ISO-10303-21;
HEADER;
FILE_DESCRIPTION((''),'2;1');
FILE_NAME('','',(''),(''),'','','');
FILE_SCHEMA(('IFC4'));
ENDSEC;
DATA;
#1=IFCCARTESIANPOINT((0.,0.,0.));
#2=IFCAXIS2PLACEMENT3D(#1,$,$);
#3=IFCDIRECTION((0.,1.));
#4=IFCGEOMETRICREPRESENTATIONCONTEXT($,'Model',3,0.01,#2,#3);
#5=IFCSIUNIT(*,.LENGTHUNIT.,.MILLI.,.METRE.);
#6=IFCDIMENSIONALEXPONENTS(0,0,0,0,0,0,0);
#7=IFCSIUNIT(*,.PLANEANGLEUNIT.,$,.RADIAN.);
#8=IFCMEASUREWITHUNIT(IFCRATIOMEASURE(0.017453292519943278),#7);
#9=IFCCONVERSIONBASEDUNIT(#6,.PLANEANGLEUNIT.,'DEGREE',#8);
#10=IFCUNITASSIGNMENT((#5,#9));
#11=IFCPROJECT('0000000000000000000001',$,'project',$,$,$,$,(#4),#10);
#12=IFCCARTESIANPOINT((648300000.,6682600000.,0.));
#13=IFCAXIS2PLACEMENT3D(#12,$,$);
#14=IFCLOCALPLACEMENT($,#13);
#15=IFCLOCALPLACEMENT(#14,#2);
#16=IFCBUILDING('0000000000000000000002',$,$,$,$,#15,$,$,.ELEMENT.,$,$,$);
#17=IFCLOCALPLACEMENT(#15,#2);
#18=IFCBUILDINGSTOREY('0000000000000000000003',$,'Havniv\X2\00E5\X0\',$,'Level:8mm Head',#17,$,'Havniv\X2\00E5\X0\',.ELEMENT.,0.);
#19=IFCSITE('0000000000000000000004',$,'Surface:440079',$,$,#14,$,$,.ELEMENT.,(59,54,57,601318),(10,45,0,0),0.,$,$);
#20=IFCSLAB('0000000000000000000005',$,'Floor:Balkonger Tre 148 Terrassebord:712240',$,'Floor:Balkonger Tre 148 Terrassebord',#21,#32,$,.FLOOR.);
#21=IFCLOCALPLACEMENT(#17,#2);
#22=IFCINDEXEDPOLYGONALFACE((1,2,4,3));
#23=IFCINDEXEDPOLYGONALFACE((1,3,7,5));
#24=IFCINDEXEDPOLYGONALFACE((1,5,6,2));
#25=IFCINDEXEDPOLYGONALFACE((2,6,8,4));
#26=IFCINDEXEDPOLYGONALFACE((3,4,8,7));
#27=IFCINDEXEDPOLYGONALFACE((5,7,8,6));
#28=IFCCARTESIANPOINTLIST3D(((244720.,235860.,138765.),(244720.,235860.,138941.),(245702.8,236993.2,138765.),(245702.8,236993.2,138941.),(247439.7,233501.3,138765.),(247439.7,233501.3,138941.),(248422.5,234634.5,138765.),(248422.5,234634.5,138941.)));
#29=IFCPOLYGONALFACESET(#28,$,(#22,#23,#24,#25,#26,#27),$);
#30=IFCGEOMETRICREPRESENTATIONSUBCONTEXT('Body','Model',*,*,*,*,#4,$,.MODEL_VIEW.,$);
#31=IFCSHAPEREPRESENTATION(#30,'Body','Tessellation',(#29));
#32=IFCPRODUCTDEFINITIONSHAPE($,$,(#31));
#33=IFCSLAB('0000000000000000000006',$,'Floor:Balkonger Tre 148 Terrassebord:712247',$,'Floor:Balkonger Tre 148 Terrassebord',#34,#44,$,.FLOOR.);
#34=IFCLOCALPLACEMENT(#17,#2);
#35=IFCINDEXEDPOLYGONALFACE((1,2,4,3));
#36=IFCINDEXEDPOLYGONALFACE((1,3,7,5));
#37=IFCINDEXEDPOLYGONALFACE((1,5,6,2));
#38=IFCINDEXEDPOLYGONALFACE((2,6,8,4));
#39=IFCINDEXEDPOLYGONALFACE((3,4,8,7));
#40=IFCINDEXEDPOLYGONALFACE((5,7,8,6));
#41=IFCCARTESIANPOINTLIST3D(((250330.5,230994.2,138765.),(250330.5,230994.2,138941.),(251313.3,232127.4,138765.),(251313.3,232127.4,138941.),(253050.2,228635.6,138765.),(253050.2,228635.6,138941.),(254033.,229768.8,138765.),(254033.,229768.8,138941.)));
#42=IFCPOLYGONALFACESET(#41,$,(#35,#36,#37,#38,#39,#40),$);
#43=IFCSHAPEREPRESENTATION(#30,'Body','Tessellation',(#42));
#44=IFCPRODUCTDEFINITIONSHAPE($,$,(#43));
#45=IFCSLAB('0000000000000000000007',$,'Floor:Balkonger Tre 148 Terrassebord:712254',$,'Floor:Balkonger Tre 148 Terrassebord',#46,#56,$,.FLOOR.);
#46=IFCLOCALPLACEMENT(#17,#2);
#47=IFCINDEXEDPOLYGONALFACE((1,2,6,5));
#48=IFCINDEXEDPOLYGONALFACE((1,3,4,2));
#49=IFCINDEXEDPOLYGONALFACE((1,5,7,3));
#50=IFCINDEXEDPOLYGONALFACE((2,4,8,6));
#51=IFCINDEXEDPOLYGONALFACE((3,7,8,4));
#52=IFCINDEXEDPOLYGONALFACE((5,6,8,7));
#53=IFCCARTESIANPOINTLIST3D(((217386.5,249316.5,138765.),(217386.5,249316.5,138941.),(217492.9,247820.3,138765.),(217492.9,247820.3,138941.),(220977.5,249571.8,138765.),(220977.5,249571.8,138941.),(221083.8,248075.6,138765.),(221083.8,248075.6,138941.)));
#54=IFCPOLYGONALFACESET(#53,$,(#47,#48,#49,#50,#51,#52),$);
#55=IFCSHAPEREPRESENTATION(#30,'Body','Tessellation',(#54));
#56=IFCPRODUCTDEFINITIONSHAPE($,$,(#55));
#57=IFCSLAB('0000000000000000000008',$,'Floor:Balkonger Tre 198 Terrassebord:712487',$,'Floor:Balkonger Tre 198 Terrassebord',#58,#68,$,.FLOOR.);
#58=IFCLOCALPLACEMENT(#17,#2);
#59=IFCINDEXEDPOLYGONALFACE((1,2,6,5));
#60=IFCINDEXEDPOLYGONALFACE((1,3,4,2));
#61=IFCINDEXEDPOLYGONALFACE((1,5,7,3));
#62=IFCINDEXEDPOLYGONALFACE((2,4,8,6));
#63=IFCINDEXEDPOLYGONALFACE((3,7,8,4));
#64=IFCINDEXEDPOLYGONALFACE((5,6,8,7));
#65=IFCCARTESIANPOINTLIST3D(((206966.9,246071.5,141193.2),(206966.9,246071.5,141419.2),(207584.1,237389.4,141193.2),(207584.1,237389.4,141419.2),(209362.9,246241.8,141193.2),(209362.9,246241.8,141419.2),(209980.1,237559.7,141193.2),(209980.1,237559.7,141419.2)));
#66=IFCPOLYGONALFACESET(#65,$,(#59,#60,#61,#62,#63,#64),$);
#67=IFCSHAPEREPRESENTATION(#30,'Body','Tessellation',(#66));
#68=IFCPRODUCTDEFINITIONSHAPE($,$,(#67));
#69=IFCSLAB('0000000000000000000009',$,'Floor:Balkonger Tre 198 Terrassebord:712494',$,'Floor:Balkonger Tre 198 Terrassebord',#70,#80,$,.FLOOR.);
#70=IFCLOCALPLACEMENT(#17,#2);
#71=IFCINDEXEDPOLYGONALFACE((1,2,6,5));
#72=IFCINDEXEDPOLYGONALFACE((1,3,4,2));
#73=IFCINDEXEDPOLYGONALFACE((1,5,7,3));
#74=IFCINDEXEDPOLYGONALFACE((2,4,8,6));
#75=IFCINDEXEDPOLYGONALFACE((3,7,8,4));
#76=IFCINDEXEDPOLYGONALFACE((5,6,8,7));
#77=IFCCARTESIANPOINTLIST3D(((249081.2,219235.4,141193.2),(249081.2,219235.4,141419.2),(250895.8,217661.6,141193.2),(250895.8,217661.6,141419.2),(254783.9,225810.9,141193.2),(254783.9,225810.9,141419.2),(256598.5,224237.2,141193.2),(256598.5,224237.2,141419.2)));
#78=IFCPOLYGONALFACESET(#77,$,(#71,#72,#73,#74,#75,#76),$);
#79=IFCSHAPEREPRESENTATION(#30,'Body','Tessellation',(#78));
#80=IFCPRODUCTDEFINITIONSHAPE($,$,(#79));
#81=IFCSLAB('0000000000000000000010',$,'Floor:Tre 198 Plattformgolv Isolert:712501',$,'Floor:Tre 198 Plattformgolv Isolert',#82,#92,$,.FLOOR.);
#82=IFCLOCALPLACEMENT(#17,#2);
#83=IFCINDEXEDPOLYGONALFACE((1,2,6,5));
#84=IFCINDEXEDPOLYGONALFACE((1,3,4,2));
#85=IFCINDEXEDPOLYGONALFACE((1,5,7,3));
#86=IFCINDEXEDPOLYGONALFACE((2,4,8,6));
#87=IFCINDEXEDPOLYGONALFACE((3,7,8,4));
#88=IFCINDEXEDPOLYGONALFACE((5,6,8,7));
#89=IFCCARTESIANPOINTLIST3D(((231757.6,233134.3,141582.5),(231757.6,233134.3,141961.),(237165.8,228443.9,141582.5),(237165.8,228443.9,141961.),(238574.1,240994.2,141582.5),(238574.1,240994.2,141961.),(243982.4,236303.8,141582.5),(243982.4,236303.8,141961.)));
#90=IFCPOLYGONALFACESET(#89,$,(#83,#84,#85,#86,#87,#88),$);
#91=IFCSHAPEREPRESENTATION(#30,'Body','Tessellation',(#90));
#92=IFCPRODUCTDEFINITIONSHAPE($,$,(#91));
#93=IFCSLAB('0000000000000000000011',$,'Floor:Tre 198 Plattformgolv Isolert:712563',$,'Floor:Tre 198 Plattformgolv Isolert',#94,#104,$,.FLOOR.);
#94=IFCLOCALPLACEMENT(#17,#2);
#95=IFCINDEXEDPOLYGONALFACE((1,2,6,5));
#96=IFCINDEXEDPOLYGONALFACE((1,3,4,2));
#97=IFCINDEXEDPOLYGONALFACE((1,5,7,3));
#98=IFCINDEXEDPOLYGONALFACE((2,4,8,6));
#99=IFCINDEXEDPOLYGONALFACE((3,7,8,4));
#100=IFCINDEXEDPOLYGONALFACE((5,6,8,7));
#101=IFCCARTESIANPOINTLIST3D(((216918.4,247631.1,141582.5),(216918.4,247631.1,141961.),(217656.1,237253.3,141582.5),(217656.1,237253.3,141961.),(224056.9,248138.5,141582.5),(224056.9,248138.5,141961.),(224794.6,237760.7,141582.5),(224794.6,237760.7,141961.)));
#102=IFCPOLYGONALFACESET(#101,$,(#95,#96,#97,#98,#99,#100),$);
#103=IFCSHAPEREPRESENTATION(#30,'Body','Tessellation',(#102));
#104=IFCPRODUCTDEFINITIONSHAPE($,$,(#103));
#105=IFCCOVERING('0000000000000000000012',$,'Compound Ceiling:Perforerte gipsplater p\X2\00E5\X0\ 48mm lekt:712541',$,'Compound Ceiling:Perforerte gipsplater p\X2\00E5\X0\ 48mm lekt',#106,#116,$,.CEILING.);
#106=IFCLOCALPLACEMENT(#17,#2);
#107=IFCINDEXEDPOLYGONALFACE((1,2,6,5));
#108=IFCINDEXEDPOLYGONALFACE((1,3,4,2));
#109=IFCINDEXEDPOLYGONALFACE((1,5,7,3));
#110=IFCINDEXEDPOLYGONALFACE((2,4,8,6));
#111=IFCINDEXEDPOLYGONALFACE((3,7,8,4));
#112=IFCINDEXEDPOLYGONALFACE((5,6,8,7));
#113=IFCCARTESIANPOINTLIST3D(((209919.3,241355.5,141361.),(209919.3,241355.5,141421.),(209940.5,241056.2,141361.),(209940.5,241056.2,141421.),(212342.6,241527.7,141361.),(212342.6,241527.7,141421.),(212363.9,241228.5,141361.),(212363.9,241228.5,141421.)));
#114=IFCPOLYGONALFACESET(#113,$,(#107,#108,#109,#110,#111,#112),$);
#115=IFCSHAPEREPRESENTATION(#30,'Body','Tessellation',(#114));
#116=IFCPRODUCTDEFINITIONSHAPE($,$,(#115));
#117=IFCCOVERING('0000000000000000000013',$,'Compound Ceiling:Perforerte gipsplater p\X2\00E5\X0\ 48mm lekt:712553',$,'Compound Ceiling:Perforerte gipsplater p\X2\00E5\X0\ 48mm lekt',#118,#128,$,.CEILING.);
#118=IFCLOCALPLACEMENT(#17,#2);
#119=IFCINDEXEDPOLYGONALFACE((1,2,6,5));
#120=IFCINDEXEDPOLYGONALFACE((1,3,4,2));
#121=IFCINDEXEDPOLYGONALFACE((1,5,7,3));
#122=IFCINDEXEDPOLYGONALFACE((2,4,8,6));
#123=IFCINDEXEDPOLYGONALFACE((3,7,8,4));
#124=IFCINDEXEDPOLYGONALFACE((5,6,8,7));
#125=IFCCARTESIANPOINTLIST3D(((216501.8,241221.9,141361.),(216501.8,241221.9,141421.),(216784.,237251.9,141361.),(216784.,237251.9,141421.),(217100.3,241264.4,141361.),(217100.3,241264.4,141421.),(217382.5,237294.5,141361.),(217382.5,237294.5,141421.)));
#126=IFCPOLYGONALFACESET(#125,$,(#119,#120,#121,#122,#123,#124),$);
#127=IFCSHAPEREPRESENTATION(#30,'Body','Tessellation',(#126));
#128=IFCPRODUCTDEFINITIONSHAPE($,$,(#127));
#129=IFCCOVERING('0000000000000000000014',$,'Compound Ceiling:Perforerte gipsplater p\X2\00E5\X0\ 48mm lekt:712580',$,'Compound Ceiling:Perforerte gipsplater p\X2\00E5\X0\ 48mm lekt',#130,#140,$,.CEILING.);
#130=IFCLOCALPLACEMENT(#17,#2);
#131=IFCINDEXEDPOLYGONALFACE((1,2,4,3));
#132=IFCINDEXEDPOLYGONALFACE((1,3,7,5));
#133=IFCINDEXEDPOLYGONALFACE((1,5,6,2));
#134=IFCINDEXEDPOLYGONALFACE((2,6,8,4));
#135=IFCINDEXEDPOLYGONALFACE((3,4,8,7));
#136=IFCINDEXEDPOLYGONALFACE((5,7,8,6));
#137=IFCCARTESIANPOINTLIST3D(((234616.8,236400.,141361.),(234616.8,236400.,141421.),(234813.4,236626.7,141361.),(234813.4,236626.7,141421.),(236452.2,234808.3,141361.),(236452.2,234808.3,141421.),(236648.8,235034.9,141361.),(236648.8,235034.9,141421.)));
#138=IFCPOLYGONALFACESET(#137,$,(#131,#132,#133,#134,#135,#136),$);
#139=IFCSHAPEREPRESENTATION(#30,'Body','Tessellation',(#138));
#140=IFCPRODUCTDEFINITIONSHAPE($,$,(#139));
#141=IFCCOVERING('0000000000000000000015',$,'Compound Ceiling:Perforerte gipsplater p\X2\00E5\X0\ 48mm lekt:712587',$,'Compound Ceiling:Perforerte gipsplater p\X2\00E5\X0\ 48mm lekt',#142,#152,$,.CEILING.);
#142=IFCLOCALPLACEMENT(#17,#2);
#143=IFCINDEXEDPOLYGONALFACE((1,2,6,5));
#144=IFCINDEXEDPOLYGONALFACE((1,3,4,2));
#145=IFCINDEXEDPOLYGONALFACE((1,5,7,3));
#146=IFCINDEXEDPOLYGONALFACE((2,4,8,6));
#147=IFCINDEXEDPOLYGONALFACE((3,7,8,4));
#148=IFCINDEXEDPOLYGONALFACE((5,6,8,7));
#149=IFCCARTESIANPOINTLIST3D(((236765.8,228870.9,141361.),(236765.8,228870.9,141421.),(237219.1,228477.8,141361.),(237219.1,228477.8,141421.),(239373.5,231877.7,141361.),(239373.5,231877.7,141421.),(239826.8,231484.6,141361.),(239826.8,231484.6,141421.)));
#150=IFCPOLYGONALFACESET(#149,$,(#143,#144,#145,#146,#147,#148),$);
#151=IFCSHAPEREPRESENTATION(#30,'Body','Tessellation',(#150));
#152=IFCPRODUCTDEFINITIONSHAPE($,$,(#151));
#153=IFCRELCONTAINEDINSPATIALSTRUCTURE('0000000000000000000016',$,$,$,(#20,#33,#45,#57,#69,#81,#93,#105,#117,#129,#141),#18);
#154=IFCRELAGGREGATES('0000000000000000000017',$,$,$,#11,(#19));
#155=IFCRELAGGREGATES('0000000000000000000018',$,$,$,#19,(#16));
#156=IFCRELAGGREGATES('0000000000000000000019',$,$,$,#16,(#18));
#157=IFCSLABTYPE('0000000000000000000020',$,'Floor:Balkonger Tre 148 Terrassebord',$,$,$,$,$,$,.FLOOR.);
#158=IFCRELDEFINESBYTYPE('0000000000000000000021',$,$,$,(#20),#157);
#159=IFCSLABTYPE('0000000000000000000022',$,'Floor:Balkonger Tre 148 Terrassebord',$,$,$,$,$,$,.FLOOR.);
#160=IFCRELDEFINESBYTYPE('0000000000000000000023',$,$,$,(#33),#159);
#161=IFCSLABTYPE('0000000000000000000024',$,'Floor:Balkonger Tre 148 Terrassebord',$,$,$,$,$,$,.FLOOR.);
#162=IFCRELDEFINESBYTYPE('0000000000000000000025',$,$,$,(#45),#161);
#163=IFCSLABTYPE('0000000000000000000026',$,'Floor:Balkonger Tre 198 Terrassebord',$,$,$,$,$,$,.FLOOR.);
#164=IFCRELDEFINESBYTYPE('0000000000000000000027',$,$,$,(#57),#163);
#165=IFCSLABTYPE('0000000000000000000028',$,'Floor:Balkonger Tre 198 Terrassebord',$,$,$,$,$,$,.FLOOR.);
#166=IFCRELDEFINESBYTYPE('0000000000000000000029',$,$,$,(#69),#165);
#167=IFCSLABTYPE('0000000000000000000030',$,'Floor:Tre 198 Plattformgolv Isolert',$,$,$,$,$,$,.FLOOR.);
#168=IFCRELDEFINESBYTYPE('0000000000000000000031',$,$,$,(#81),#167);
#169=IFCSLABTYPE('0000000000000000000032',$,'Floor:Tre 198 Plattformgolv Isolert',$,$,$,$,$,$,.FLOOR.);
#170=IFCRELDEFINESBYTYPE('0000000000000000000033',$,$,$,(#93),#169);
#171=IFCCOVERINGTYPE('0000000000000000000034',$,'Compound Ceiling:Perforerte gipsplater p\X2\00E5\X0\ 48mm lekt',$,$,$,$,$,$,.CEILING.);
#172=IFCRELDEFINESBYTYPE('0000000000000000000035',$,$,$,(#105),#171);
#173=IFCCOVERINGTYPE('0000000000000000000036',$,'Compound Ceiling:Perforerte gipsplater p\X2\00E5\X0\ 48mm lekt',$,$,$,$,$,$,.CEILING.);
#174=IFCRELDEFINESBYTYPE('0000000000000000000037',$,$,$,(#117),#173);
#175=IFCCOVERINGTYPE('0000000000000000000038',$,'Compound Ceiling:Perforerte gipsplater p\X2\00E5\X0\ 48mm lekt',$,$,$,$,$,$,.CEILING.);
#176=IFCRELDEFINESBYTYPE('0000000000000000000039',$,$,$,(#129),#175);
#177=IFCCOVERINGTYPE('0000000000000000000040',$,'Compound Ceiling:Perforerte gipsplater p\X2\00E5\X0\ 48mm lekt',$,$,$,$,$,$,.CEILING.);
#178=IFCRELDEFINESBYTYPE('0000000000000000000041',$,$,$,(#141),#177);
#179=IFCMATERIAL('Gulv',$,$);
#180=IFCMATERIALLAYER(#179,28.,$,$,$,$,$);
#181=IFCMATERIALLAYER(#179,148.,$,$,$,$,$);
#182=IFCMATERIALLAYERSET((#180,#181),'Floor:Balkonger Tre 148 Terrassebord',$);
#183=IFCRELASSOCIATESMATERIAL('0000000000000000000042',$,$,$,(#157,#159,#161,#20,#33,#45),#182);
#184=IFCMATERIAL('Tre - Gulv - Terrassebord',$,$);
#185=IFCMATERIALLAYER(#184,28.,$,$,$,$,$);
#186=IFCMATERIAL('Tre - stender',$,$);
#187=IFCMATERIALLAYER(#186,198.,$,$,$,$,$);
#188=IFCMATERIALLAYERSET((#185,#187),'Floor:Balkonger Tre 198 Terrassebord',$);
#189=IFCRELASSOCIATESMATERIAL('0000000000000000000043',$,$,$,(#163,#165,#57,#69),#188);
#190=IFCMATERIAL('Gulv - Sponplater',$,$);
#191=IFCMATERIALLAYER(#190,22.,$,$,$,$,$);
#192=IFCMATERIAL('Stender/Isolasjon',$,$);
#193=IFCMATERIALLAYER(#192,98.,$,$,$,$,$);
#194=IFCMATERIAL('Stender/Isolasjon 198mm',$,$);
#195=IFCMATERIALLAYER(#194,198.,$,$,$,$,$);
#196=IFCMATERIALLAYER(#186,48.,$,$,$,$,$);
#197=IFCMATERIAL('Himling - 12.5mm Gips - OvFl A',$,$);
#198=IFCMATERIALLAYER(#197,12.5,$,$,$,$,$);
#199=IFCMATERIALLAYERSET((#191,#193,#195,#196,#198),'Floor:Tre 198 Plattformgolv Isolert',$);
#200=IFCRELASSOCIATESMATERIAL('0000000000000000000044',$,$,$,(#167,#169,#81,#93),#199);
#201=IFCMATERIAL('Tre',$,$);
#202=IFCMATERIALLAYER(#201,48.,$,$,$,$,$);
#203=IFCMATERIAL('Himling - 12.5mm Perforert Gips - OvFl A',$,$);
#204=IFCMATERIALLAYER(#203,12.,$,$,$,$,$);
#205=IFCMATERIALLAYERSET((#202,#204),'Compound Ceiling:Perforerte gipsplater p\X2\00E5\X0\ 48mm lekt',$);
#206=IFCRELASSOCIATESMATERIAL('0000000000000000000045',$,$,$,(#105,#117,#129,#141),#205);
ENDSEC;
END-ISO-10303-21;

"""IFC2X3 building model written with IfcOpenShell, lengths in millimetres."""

from ifc_helpers import new_model, entity, si_unit, converted_unit, direction, frame, frame_2d, origin, place, context, subcontext, project, spatial, rectangle, extrude, material, layer, layer_set, layer_usage, type_object, element, save


model = new_model("IFC2X3")

# Units and contexts
model_context = context("Model", 3, precision=0.01, world=origin(), true_north=direction((0.0, 1.0)))
body_context = subcontext(model_context, "Body", "Model", "MODEL_VIEW")
ifc_project = project(units=[si_unit("LENGTHUNIT", "METRE", prefix="MILLI"), converted_unit("PLANEANGLEUNIT", "DEGREE", entity("IfcRatioMeasure", 0.017453292519943278), si_unit("PLANEANGLEUNIT", "RADIAN"), dimensions=[0, 0, 0, 0, 0, 0, 0])], contexts=[model_context])

# Site, building, storey
site_placement = place(None, frame((648300000.0, 6682600000.0, 0.0)))
site = spatial("IfcSite", under=ifc_project, at=site_placement, Name="Surface:440079", CompositionType="ELEMENT", RefLatitude=(59, 54, 57, 601318), RefLongitude=(10, 45, 0, 0), RefElevation=0.0)
building_placement = place(site_placement, origin())
building = spatial("IfcBuilding", under=site, at=building_placement, CompositionType="ELEMENT")
storey_placement = place(building_placement, origin())
storey = spatial("IfcBuildingStorey", under=building, at=storey_placement, Name="Havnivå", ObjectType="Level:8mm Head", LongName="Havnivå", CompositionType="ELEMENT", Elevation=0.0)

# Slabs
ifc_material_1 = material(Name="Gulv")
ifc_layer_1 = layer(ifc_material_1, 28.0)
ifc_layer_2 = layer(ifc_material_1, 148.0)
ifc_layer_set_1 = layer_set([ifc_layer_1, ifc_layer_2], Name="Floor:Balkonger Tre 148 Terrassebord")
ifc_material_2 = material(Name="Gulv - Sponplater")
ifc_layer_3 = layer(ifc_material_2, 22.0)
ifc_material_3 = material(Name="Stender/Isolasjon")
ifc_layer_4 = layer(ifc_material_3, 98.0)
ifc_material_4 = material(Name="Stender/Isolasjon 198mm")
ifc_layer_5 = layer(ifc_material_4, 198.0)
ifc_material_5 = material(Name="Tre - stender")
ifc_layer_6 = layer(ifc_material_5, 48.0)
ifc_material_6 = material(Name="Himling - 12.5mm Gips - OvFl A")
ifc_layer_7 = layer(ifc_material_6, 12.5)
ifc_layer_set_2 = layer_set([ifc_layer_3, ifc_layer_4, ifc_layer_5, ifc_layer_6, ifc_layer_7], Name="Floor:Tre 198 Plattformgolv Isolert")
ifc_layer_usage_1 = layer_usage(ifc_layer_set_1, "AXIS3", "POSITIVE", 0.0)
slab_type_1 = type_object("IfcSlabType", Name="Floor:Balkonger Tre 148 Terrassebord", PredefinedType="FLOOR", material=ifc_layer_set_1)
slab_1_placement = place(storey_placement, origin())
element("IfcSlab", 1, at=slab_1_placement, inside=storey, type_object=slab_type_1, material=ifc_layer_usage_1, Name="Floor:Balkonger Tre 148 Terrassebord:712240", ObjectType="Floor:Balkonger Tre 148 Terrassebord", PredefinedType="FLOOR", context=body_context, shape_type="SweptSolid", body=[
    extrude(rectangle(XDim=1500.0, YDim=3600.0, at=frame_2d((0.0, 0.0), x_axis=(1.0, 0.0))), frame((246571.3, 235247.2, 138941.0), z_axis=(0.0, 0.0, -1.0), x_axis=(-0.655187, -0.755467, 0.0)), (0.0, 0.0, 1.0), 176.0),
])
ifc_layer_usage_2 = layer_usage(ifc_layer_set_1, "AXIS3", "POSITIVE", 0.0)
slab_type_2 = type_object("IfcSlabType", Name="Floor:Balkonger Tre 148 Terrassebord", PredefinedType="FLOOR", material=ifc_layer_set_1)
slab_2_placement = place(storey_placement, origin())
element("IfcSlab", 2, at=slab_2_placement, inside=storey, type_object=slab_type_2, material=ifc_layer_usage_2, Name="Floor:Balkonger Tre 148 Terrassebord:712247", ObjectType="Floor:Balkonger Tre 148 Terrassebord", PredefinedType="FLOOR", context=body_context, shape_type="SweptSolid", body=[
    extrude(rectangle(XDim=1500.0, YDim=3600.0, at=frame_2d((0.0, 0.0), x_axis=(1.0, 0.0))), frame((252181.7, 230381.5, 138941.0), z_axis=(0.0, 0.0, -1.0), x_axis=(-0.655187, -0.755467, 0.0)), (0.0, 0.0, 1.0), 176.0),
])
ifc_layer_usage_3 = layer_usage(ifc_layer_set_1, "AXIS3", "POSITIVE", 0.0)
slab_type_3 = type_object("IfcSlabType", Name="Floor:Balkonger Tre 148 Terrassebord", PredefinedType="FLOOR", material=ifc_layer_set_1)
slab_3_placement = place(storey_placement, origin())
element("IfcSlab", 3, at=slab_3_placement, inside=storey, type_object=slab_type_3, material=ifc_layer_usage_3, Name="Floor:Balkonger Tre 148 Terrassebord:712254", ObjectType="Floor:Balkonger Tre 148 Terrassebord", PredefinedType="FLOOR", context=body_context, shape_type="SweptSolid", body=[
    extrude(rectangle(XDim=1500.0, YDim=3600.0, at=frame_2d((0.0, 0.0), x_axis=(1.0, 0.0))), frame((219235.2, 248696.0, 138941.0), z_axis=(0.0, 0.0, -1.0), x_axis=(0.070908, -0.997483, 0.0)), (0.0, 0.0, 1.0), 176.0),
])
ifc_material_7 = material(Name="Tre - Gulv - Terrassebord")
ifc_layer_8 = layer(ifc_material_7, 28.0)
ifc_layer_9 = layer(ifc_material_5, 198.0)
ifc_layer_set_3 = layer_set([ifc_layer_8, ifc_layer_9], Name="Floor:Balkonger Tre 198 Terrassebord")
ifc_layer_usage_4 = layer_usage(ifc_layer_set_3, "AXIS3", "POSITIVE", 0.0)
slab_type_4 = type_object("IfcSlabType", Name="Floor:Balkonger Tre 198 Terrassebord", PredefinedType="FLOOR", material=ifc_layer_set_3)
slab_4_placement = place(storey_placement, origin())
element("IfcSlab", 4, at=slab_4_placement, inside=storey, type_object=slab_type_4, material=ifc_layer_usage_4, Name="Floor:Balkonger Tre 198 Terrassebord:712487", ObjectType="Floor:Balkonger Tre 198 Terrassebord", PredefinedType="FLOOR", context=body_context, shape_type="SweptSolid", body=[
    extrude(rectangle(XDim=2402.0, YDim=8704.0, at=frame_2d((0.0, 0.0), x_axis=(1.0, 0.0))), frame((208473.5, 241815.6, 141419.2), z_axis=(0.0, 0.0, -1.0), x_axis=(0.997483, 0.070908, 0.0)), (0.0, 0.0, 1.0), 226.0),
])
ifc_layer_usage_5 = layer_usage(ifc_layer_set_3, "AXIS3", "POSITIVE", 0.0)
slab_type_5 = type_object("IfcSlabType", Name="Floor:Balkonger Tre 198 Terrassebord", PredefinedType="FLOOR", material=ifc_layer_set_3)
slab_5_placement = place(storey_placement, origin())
element("IfcSlab", 5, at=slab_5_placement, inside=storey, type_object=slab_type_5, material=ifc_layer_usage_5, Name="Floor:Balkonger Tre 198 Terrassebord:712494", ObjectType="Floor:Balkonger Tre 198 Terrassebord", PredefinedType="FLOOR", context=body_context, shape_type="SweptSolid", body=[
    extrude(rectangle(XDim=8704.0, YDim=2402.0, at=frame_2d((0.0, 0.0), x_axis=(1.0, 0.0))), frame((252839.8, 221736.3, 141419.2), z_axis=(0.0, 0.0, -1.0), x_axis=(-0.655187, -0.755467, 0.0)), (0.0, 0.0, 1.0), 226.0),
])
ifc_layer_usage_6 = layer_usage(ifc_layer_set_2, "AXIS3", "POSITIVE", 0.0)
slab_type_6 = type_object("IfcSlabType", Name="Floor:Tre 198 Plattformgolv Isolert", PredefinedType="FLOOR", material=ifc_layer_set_2)
slab_6_placement = place(storey_placement, origin())
element("IfcSlab", 6, at=slab_6_placement, inside=storey, type_object=slab_type_6, material=ifc_layer_usage_6, Name="Floor:Tre 198 Plattformgolv Isolert:712501", ObjectType="Floor:Tre 198 Plattformgolv Isolert", PredefinedType="FLOOR", context=body_context, shape_type="SweptSolid", body=[
    extrude(rectangle(XDim=7158.8, YDim=10404.0, at=frame_2d((0.0, 0.0), x_axis=(1.0, 0.0))), frame((237870.0, 234719.1, 141961.0), z_axis=(0.0, 0.0, -1.0), x_axis=(0.755467, -0.655187, 0.0)), (0.0, 0.0, 1.0), 378.5),
])
ifc_layer_usage_7 = layer_usage(ifc_layer_set_2, "AXIS3", "POSITIVE", 0.0)
slab_type_7 = type_object("IfcSlabType", Name="Floor:Tre 198 Plattformgolv Isolert", PredefinedType="FLOOR", material=ifc_layer_set_2)
slab_7_placement = place(storey_placement, origin())
element("IfcSlab", 7, at=slab_7_placement, inside=storey, type_object=slab_type_7, material=ifc_layer_usage_7, Name="Floor:Tre 198 Plattformgolv Isolert:712563", ObjectType="Floor:Tre 198 Plattformgolv Isolert", PredefinedType="FLOOR", context=body_context, shape_type="SweptSolid", body=[
    extrude(rectangle(XDim=10404.0, YDim=7156.5, at=frame_2d((0.0, 0.0), x_axis=(1.0, 0.0))), frame((220856.5, 242695.9, 141961.0), z_axis=(0.0, 0.0, -1.0), x_axis=(0.070908, -0.997483, 0.0)), (0.0, 0.0, 1.0), 378.5),
])

# Coverings
ifc_material_8 = material(Name="Tre")
ifc_layer_10 = layer(ifc_material_8, 48.0)
ifc_material_9 = material(Name="Himling - 12.5mm Perforert Gips - OvFl A")
ifc_layer_11 = layer(ifc_material_9, 12.0)
ifc_layer_set_4 = layer_set([ifc_layer_10, ifc_layer_11], Name="Compound Ceiling:Perforerte gipsplater på 48mm lekt")
ifc_layer_usage_8 = layer_usage(ifc_layer_set_4, "AXIS3", "POSITIVE", 0.0)
covering_type_1 = type_object("IfcCoveringType", Name="Compound Ceiling:Perforerte gipsplater på 48mm lekt", PredefinedType="CEILING")
covering_1_placement = place(storey_placement, origin())
element("IfcCovering", 8, at=covering_1_placement, inside=storey, type_object=covering_type_1, material=ifc_layer_usage_8, Name="Compound Ceiling:Perforerte gipsplater på 48mm lekt:712541", ObjectType="Compound Ceiling:Perforerte gipsplater på 48mm lekt", PredefinedType="CEILING", context=body_context, shape_type="SweptSolid", body=[
    extrude(rectangle(XDim=300.0, YDim=2429.5, at=frame_2d((0.0, 0.0), x_axis=(1.0, 0.0))), frame((211141.6, 241292.0, 141361.0), z_axis=(0.0, 0.0, 1.0), x_axis=(-0.070908, 0.997483, 0.0)), (0.0, 0.0, 1.0), 60.0),
])
ifc_layer_usage_9 = layer_usage(ifc_layer_set_4, "AXIS3", "POSITIVE", 0.0)
covering_type_2 = type_object("IfcCoveringType", Name="Compound Ceiling:Perforerte gipsplater på 48mm lekt", PredefinedType="CEILING")
covering_2_placement = place(storey_placement, origin())
element("IfcCovering", 9, at=covering_2_placement, inside=storey, type_object=covering_type_2, material=ifc_layer_usage_9, Name="Compound Ceiling:Perforerte gipsplater på 48mm lekt:712553", ObjectType="Compound Ceiling:Perforerte gipsplater på 48mm lekt", PredefinedType="CEILING", context=body_context, shape_type="SweptSolid", body=[
    extrude(rectangle(XDim=3980.0, YDim=600.0, at=frame_2d((0.0, 0.0), x_axis=(1.0, 0.0))), frame((216942.2, 239258.2, 141361.0), z_axis=(0.0, 0.0, 1.0), x_axis=(0.070908, -0.997483, 0.0)), (0.0, 0.0, 1.0), 60.0),
])
ifc_layer_usage_10 = layer_usage(ifc_layer_set_4, "AXIS3", "POSITIVE", 0.0)
covering_type_3 = type_object("IfcCoveringType", Name="Compound Ceiling:Perforerte gipsplater på 48mm lekt", PredefinedType="CEILING")
covering_3_placement = place(storey_placement, origin())
element("IfcCovering", 10, at=covering_3_placement, inside=storey, type_object=covering_type_3, material=ifc_layer_usage_10, Name="Compound Ceiling:Perforerte gipsplater på 48mm lekt:712580", ObjectType="Compound Ceiling:Perforerte gipsplater på 48mm lekt", PredefinedType="CEILING", context=body_context, shape_type="SweptSolid", body=[
    extrude(rectangle(XDim=300.0, YDim=2429.5, at=frame_2d((0.0, 0.0), x_axis=(1.0, 0.0))), frame((235632.8, 235717.5, 141361.0), z_axis=(0.0, 0.0, 1.0), x_axis=(0.655187, 0.755467, 0.0)), (0.0, 0.0, 1.0), 60.0),
])
ifc_layer_usage_11 = layer_usage(ifc_layer_set_4, "AXIS3", "POSITIVE", 0.0)
covering_type_4 = type_object("IfcCoveringType", Name="Compound Ceiling:Perforerte gipsplater på 48mm lekt", PredefinedType="CEILING")
covering_4_placement = place(storey_placement, origin())
element("IfcCovering", 11, at=covering_4_placement, inside=storey, type_object=covering_type_4, material=ifc_layer_usage_11, Name="Compound Ceiling:Perforerte gipsplater på 48mm lekt:712587", ObjectType="Compound Ceiling:Perforerte gipsplater på 48mm lekt", PredefinedType="CEILING", context=body_context, shape_type="SweptSolid", body=[
    extrude(rectangle(XDim=3980.0, YDim=600.0, at=frame_2d((0.0, 0.0), x_axis=(1.0, 0.0))), frame((238296.3, 230177.7, 141361.0), z_axis=(0.0, 0.0, 1.0), x_axis=(-0.655187, -0.755467, 0.0)), (0.0, 0.0, 1.0), 60.0),
])

save(model, "model.ifc")
